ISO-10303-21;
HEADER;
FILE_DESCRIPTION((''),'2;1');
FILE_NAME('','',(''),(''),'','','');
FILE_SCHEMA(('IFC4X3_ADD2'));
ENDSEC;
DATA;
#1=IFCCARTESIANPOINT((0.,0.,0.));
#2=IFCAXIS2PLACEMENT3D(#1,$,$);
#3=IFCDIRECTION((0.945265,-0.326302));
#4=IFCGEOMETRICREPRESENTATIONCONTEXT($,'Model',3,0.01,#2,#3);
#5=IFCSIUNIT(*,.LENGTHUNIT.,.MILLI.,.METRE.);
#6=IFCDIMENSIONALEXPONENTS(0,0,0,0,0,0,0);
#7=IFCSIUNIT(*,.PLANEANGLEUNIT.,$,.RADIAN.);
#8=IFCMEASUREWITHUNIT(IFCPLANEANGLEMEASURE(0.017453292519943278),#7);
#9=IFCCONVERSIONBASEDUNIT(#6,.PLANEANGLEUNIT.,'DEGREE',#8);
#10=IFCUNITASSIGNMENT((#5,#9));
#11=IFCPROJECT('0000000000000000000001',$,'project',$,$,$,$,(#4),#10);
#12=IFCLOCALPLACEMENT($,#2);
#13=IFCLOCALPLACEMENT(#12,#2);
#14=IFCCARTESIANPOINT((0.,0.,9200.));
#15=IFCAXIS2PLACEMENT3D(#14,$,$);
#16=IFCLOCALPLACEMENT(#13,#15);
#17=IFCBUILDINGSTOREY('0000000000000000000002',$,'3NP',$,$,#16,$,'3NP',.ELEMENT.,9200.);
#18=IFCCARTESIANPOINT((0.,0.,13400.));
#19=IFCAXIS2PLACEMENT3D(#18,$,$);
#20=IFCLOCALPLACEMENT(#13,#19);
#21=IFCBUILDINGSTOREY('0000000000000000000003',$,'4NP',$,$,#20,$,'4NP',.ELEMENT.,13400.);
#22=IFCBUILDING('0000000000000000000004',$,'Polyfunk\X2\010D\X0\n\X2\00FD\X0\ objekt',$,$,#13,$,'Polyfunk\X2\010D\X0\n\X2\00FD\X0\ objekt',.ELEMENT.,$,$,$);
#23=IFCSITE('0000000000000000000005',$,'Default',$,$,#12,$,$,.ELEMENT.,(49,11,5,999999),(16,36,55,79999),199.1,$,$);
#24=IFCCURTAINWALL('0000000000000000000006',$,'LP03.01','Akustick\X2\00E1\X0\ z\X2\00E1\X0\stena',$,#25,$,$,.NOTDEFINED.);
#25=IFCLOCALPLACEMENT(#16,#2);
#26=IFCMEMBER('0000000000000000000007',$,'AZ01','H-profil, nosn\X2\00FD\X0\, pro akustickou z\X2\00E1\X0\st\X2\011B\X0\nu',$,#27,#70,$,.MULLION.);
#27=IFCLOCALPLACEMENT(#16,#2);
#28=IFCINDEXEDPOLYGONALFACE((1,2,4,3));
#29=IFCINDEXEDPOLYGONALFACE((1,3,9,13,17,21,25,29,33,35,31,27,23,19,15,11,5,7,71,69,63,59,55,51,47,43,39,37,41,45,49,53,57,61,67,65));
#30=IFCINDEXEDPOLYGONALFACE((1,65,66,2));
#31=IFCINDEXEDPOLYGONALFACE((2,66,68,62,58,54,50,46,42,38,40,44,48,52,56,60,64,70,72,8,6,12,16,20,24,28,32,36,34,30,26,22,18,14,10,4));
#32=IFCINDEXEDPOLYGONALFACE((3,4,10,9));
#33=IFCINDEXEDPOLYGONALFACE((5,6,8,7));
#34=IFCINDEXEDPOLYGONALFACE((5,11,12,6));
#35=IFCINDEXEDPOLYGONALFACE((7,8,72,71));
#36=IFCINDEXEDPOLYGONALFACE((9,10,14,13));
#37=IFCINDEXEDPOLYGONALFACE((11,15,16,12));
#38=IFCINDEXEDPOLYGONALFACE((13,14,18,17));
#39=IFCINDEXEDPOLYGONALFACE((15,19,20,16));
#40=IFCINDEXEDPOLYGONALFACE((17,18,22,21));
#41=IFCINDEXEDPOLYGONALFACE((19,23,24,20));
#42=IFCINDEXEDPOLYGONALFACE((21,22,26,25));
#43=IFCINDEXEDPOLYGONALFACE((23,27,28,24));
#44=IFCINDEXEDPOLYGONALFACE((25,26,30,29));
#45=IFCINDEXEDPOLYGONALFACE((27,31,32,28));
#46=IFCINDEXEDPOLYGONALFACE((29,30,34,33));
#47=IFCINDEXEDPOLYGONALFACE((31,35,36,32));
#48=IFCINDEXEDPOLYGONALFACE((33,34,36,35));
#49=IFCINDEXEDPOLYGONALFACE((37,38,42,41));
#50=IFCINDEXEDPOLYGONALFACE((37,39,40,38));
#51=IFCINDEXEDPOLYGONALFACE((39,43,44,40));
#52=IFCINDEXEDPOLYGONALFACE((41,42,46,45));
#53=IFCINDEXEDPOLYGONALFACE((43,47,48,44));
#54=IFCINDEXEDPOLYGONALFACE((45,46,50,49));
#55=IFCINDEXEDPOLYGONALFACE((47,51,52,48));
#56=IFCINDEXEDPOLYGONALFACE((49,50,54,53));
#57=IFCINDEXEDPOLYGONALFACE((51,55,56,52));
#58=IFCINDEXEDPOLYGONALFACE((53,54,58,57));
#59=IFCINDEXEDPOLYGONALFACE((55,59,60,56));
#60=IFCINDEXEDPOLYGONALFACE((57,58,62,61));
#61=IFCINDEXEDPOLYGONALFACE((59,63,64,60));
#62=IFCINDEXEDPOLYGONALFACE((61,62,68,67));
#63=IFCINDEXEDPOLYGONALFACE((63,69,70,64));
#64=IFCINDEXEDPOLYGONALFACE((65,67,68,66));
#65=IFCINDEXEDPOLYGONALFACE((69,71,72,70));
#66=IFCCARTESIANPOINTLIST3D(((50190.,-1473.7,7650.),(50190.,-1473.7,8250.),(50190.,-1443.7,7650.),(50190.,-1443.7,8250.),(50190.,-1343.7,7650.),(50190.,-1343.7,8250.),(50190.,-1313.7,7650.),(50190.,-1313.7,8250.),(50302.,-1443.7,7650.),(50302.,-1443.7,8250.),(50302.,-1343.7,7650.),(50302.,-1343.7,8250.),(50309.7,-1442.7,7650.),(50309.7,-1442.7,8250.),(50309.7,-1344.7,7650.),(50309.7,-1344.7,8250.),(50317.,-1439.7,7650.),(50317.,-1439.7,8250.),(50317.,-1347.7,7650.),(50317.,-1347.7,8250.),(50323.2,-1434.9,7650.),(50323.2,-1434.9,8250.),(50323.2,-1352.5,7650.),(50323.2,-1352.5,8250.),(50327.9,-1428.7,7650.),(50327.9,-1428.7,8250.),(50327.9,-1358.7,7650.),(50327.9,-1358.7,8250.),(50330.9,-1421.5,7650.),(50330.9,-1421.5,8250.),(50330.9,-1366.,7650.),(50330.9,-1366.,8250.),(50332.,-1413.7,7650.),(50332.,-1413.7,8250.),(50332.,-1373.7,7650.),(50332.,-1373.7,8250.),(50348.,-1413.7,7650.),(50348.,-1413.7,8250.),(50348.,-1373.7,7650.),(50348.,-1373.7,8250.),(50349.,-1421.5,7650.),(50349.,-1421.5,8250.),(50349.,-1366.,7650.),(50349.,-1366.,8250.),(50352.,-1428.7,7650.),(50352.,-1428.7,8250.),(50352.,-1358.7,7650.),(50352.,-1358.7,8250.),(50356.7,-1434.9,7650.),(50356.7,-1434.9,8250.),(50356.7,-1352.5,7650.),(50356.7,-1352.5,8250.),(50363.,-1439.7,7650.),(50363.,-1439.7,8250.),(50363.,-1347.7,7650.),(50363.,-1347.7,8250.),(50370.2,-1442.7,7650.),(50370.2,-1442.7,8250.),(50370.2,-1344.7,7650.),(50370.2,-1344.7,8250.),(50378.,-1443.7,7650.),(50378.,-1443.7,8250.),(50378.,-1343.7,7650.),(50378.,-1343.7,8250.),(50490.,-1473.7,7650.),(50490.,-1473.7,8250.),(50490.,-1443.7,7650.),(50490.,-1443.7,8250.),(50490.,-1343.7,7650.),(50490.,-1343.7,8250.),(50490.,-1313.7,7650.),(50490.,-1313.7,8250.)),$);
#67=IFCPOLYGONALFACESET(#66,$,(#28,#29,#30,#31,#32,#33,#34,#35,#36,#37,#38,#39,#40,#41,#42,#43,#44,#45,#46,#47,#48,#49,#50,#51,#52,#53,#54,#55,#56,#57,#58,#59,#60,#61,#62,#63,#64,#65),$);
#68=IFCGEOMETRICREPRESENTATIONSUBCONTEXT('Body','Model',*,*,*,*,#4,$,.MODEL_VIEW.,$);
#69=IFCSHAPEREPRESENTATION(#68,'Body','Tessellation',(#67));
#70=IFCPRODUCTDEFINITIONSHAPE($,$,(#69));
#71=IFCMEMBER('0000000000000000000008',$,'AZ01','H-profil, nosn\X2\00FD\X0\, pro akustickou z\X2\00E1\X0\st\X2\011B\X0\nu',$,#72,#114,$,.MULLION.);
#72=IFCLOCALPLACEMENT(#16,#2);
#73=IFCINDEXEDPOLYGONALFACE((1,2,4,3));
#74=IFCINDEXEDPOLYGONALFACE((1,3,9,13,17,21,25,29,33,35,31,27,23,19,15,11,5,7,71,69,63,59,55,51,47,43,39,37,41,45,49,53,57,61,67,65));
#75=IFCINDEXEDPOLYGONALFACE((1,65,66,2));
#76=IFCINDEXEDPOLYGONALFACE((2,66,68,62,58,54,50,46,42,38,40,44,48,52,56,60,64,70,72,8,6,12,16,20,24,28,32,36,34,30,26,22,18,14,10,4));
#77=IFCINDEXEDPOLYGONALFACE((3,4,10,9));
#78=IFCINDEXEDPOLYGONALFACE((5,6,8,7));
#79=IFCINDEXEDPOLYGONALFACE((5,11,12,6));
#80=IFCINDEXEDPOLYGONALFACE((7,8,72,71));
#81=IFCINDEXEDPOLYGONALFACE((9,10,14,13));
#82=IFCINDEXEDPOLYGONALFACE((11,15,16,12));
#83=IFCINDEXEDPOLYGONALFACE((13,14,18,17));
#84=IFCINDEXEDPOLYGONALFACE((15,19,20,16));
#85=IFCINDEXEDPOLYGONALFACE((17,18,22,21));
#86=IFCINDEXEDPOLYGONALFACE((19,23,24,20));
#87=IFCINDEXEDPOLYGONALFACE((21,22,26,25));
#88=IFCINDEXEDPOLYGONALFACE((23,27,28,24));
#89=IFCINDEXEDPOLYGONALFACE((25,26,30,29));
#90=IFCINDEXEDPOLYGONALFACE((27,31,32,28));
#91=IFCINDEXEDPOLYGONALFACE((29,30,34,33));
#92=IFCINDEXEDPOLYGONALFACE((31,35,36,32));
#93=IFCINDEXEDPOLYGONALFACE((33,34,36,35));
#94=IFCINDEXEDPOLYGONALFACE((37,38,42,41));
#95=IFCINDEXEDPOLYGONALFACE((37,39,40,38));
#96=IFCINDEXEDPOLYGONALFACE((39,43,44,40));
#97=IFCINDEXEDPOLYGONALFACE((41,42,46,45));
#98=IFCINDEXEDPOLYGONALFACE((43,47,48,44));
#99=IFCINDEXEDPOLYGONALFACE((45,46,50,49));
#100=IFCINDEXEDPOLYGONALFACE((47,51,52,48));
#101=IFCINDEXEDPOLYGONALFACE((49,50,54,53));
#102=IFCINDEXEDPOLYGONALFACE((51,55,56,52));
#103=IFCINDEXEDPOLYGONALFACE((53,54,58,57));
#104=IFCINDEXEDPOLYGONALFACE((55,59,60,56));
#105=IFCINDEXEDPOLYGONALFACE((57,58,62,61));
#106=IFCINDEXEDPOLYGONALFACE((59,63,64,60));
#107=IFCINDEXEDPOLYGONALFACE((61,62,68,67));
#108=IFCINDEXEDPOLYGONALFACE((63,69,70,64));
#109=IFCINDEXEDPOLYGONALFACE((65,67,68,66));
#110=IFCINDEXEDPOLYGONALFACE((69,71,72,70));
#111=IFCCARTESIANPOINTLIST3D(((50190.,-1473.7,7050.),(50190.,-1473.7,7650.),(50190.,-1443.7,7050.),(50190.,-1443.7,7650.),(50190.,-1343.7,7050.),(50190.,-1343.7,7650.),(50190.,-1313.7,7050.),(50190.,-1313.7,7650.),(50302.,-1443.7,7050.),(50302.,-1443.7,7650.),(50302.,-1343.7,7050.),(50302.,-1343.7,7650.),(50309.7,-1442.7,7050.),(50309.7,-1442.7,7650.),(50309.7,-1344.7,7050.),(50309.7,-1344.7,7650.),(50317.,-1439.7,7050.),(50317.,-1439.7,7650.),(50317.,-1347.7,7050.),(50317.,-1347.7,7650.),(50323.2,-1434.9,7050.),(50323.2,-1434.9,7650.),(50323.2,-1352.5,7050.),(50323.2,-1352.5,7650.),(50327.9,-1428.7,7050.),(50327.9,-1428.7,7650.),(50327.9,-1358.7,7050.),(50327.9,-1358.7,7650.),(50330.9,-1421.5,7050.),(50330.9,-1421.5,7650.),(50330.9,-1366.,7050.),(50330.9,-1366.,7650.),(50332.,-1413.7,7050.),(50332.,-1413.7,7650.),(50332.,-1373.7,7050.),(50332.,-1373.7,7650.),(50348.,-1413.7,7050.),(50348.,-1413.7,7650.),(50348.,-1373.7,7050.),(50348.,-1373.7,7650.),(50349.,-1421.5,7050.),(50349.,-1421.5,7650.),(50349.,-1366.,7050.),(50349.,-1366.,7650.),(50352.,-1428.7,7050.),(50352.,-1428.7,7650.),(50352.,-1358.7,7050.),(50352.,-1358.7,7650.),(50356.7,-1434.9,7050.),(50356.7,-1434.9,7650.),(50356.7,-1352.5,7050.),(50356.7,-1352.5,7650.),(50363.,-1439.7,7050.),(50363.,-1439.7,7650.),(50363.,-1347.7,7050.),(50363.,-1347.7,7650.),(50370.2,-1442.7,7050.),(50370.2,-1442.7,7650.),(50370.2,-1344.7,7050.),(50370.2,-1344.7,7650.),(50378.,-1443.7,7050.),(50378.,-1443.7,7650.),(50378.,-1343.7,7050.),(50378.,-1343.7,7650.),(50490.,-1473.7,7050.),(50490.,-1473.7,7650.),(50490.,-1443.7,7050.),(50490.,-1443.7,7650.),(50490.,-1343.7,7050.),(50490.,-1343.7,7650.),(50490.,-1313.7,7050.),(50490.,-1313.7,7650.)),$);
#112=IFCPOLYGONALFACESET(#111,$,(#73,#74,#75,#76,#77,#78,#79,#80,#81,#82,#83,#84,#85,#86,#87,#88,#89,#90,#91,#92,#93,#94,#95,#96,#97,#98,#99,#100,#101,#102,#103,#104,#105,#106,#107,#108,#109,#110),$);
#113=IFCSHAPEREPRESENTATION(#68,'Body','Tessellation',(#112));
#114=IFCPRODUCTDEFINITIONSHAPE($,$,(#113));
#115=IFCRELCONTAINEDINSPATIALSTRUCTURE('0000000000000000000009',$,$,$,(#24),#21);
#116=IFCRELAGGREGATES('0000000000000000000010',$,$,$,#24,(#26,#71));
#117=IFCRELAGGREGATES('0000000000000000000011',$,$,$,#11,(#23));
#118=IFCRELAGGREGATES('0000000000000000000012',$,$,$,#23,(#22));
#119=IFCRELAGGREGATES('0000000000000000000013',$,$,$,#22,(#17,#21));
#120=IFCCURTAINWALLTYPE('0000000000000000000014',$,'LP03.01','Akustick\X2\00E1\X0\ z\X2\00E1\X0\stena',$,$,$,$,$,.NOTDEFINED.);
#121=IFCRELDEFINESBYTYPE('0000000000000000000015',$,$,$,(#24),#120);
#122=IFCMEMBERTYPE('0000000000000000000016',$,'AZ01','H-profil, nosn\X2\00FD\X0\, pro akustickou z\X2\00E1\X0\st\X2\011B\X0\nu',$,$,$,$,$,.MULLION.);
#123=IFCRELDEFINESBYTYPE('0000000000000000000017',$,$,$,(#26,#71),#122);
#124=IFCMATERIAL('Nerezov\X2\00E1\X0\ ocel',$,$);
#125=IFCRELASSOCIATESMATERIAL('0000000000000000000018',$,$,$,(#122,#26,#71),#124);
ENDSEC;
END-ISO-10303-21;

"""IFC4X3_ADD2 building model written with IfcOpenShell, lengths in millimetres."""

from ifc_helpers import new_model, entity, si_unit, converted_unit, direction, frame, frame_2d, origin, place, context, subcontext, project, spatial, polyline, circle_curve, parameter, trimmed, segment, composite_curve, outline, extrude, source, transform, mapped, material, material_profile, profile_set, profile_usage, type_object, element, aggregate, save


model = new_model("IFC4X3_ADD2")

# Units and contexts
model_context = context("Model", 3, precision=0.01, world=origin(), true_north=direction((0.945265, -0.326302)))
body_context = subcontext(model_context, "Body", "Model", "MODEL_VIEW")
ifc_project = project(units=[si_unit("LENGTHUNIT", "METRE", prefix="MILLI"), converted_unit("PLANEANGLEUNIT", "DEGREE", entity("IfcPlaneAngleMeasure", 0.017453292519943278), si_unit("PLANEANGLEUNIT", "RADIAN"), dimensions=[0, 0, 0, 0, 0, 0, 0])], contexts=[model_context])

# Site, building, storey
site_placement = place(None, origin())
site = spatial("IfcSite", under=ifc_project, at=site_placement, Name="Default", CompositionType="ELEMENT", RefLatitude=(49, 11, 5, 999999), RefLongitude=(16, 36, 55, 79999), RefElevation=199.1)
building_placement = place(site_placement, origin())
building = spatial("IfcBuilding", under=site, at=building_placement, Name="Polyfunkčný objekt", LongName="Polyfunkčný objekt", CompositionType="ELEMENT")
storey_1_placement = place(building_placement, frame((0.0, 0.0, 9200.0)))
storey_1 = spatial("IfcBuildingStorey", under=building, at=storey_1_placement, Name="3NP", LongName="3NP", CompositionType="ELEMENT", Elevation=9200.0)

# Shared definitions
storey_2_placement = place(building_placement, frame((0.0, 0.0, 13400.0)))
storey_2 = spatial("IfcBuildingStorey", under=building, at=storey_2_placement, Name="4NP", LongName="4NP", CompositionType="ELEMENT", Elevation=13400.0)

# Curtain wall, members
curtain_wall_type_1 = type_object("IfcCurtainWallType", Name="LP03.01", Description="Akustická zástena", PredefinedType="NOTDEFINED")
curtain_wall_1_placement = place(storey_2_placement, frame((0.0, 0.0, -13400.0)))
curtain_wall_1 = element("IfcCurtainWall", 1, at=curtain_wall_1_placement, inside=storey_2, type_object=curtain_wall_type_1, Name="LP03.01", Description="Akustická zástena", PredefinedType="NOTDEFINED")
ifc_material_1 = material(Name="Nerezová ocel")
ifc_material_profile_1 = material_profile(ifc_material_1, outline(composite_curve([segment(polyline([(50.0, -150.0), (80.0, -150.0)]), True, "CONTINUOUS"), segment(polyline([(80.0, -150.0), (80.0, 150.0)]), True, "CONTINUOUS"), segment(polyline([(80.0, 150.0), (50.0, 150.0)]), True, "CONTINUOUS"), segment(polyline([(50.0, 150.0), (50.0, 38.0)]), True, "CONTINUOUS"), segment(trimmed(circle_curve(frame_2d((20.0, 38.0), x_axis=(0.0, 1.0)), 30.0), [parameter(180.0)], [parameter(270.0)], True, "PARAMETER"), False, "CONTINUOUS"), segment(polyline([(20.0, 8.0), (-20.0, 8.0)]), True, "CONTINUOUS"), segment(trimmed(circle_curve(frame_2d((-20.0, 38.0), x_axis=(0.0, 1.0)), 30.0), [parameter(90.0)], [parameter(180.0)], True, "PARAMETER"), False, "CONTINUOUS"), segment(polyline([(-50.0, 38.0), (-50.0, 150.0)]), True, "CONTINUOUS"), segment(polyline([(-50.0, 150.0), (-80.0, 150.0)]), True, "CONTINUOUS"), segment(polyline([(-80.0, 150.0), (-80.0, -150.0)]), True, "CONTINUOUS"), segment(polyline([(-80.0, -150.0), (-50.0, -150.0)]), True, "CONTINUOUS"), segment(polyline([(-50.0, -150.0), (-50.0, -38.0)]), True, "CONTINUOUS"), segment(trimmed(circle_curve(frame_2d((-20.0, -38.0), x_axis=(0.0, 1.0)), 30.0), [parameter(0.0)], [parameter(90.0)], True, "PARAMETER"), False, "CONTINUOUS"), segment(polyline([(-20.0, -8.0), (20.0, -8.0)]), True, "CONTINUOUS"), segment(trimmed(circle_curve(frame_2d((20.0, -38.0), x_axis=(0.0, 1.0)), 30.0), [parameter(270.0)], [parameter(0.0)], True, "PARAMETER"), False, "CONTINUOUS"), segment(polyline([(50.0, -38.0), (50.0, -150.0)]), True, "CONTINUOUS")], self_intersect=False)), Name="Profil zástena")
ifc_profile_set_1 = profile_set([ifc_material_profile_1], Name="Profil zástena")
ifc_profile_usage_1 = profile_usage(ifc_profile_set_1)
member_type_1 = type_object("IfcMemberType", Name="AZ01", Description="H-profil, nosný, pro akustickou zástěnu", PredefinedType="MULLION", material=ifc_profile_set_1)
shared_shape_1 = source(origin(), body_context, "Body", "SweptSolid", [
    extrude(outline(composite_curve([segment(polyline([(-150.0, -50.0), (-150.0, -80.0)]), True, "CONTINUOUS"), segment(polyline([(-150.0, -80.0), (150.0, -80.0)]), True, "CONTINUOUS"), segment(polyline([(150.0, -80.0), (150.0, -50.0)]), True, "CONTINUOUS"), segment(polyline([(150.0, -50.0), (38.0, -50.0)]), True, "CONTINUOUS"), segment(trimmed(circle_curve(frame_2d((38.0, -20.0), x_axis=(1.0, 0.0)), 30.0), [parameter(180.0)], [parameter(270.0)], True, "PARAMETER"), False, "CONTINUOUS"), segment(polyline([(8.0, -20.0), (8.0, 20.0)]), True, "CONTINUOUS"), segment(trimmed(circle_curve(frame_2d((38.0, 20.0), x_axis=(1.0, 0.0)), 30.0), [parameter(90.0)], [parameter(180.0)], True, "PARAMETER"), False, "CONTINUOUS"), segment(polyline([(38.0, 50.0), (150.0, 50.0)]), True, "CONTINUOUS"), segment(polyline([(150.0, 50.0), (150.0, 80.0)]), True, "CONTINUOUS"), segment(polyline([(150.0, 80.0), (-150.0, 80.0)]), True, "CONTINUOUS"), segment(polyline([(-150.0, 80.0), (-150.0, 50.0)]), True, "CONTINUOUS"), segment(polyline([(-150.0, 50.0), (-38.0, 50.0)]), True, "CONTINUOUS"), segment(trimmed(circle_curve(frame_2d((-38.0, 20.0), x_axis=(1.0, 0.0)), 30.0), [parameter(0.0)], [parameter(90.0)], True, "PARAMETER"), False, "CONTINUOUS"), segment(polyline([(-8.0, 20.0), (-8.0, -20.0)]), True, "CONTINUOUS"), segment(trimmed(circle_curve(frame_2d((-38.0, -20.0), x_axis=(1.0, 0.0)), 30.0), [parameter(270.0)], [parameter(0.0)], True, "PARAMETER"), False, "CONTINUOUS"), segment(polyline([(-38.0, -50.0), (-150.0, -50.0)]), True, "CONTINUOUS")], self_intersect=False)), frame((-150.0, 0.0, -600.0), z_axis=(0.0, 0.0, -1.0), x_axis=(-1.0, 0.0, 0.0)), (0.0, 0.0, -1.0), 600.0),
])
member_1_placement = place(curtain_wall_1_placement, frame((50190.0, -1393.7, 17450.0), z_axis=(0.0, 0.0, 1.0), x_axis=(-1.0, 0.0, 0.0)))
member_1 = element("IfcMember", 2, at=member_1_placement, type_object=member_type_1, material=ifc_profile_usage_1, Name="AZ01", Description="H-profil, nosný, pro akustickou zástěnu", PredefinedType="MULLION", context=body_context, shape_type="MappedRepresentation", body=[
    mapped(shared_shape_1, transform((0.0, 0.0, 0.0), scale=1.0)),
])
member_2_placement = place(curtain_wall_1_placement, frame((50190.0, -1393.7, 16850.0), z_axis=(0.0, 0.0, 1.0), x_axis=(-1.0, 0.0, 0.0)))
member_2 = element("IfcMember", 3, at=member_2_placement, type_object=member_type_1, material=ifc_profile_usage_1, Name="AZ01", Description="H-profil, nosný, pro akustickou zástěnu", PredefinedType="MULLION", context=body_context, shape_type="MappedRepresentation", body=[
    mapped(shared_shape_1, transform((0.0, 0.0, 0.0), scale=1.0)),
])

aggregate(curtain_wall_1, [member_1, member_2])

save(model, "model.ifc")
